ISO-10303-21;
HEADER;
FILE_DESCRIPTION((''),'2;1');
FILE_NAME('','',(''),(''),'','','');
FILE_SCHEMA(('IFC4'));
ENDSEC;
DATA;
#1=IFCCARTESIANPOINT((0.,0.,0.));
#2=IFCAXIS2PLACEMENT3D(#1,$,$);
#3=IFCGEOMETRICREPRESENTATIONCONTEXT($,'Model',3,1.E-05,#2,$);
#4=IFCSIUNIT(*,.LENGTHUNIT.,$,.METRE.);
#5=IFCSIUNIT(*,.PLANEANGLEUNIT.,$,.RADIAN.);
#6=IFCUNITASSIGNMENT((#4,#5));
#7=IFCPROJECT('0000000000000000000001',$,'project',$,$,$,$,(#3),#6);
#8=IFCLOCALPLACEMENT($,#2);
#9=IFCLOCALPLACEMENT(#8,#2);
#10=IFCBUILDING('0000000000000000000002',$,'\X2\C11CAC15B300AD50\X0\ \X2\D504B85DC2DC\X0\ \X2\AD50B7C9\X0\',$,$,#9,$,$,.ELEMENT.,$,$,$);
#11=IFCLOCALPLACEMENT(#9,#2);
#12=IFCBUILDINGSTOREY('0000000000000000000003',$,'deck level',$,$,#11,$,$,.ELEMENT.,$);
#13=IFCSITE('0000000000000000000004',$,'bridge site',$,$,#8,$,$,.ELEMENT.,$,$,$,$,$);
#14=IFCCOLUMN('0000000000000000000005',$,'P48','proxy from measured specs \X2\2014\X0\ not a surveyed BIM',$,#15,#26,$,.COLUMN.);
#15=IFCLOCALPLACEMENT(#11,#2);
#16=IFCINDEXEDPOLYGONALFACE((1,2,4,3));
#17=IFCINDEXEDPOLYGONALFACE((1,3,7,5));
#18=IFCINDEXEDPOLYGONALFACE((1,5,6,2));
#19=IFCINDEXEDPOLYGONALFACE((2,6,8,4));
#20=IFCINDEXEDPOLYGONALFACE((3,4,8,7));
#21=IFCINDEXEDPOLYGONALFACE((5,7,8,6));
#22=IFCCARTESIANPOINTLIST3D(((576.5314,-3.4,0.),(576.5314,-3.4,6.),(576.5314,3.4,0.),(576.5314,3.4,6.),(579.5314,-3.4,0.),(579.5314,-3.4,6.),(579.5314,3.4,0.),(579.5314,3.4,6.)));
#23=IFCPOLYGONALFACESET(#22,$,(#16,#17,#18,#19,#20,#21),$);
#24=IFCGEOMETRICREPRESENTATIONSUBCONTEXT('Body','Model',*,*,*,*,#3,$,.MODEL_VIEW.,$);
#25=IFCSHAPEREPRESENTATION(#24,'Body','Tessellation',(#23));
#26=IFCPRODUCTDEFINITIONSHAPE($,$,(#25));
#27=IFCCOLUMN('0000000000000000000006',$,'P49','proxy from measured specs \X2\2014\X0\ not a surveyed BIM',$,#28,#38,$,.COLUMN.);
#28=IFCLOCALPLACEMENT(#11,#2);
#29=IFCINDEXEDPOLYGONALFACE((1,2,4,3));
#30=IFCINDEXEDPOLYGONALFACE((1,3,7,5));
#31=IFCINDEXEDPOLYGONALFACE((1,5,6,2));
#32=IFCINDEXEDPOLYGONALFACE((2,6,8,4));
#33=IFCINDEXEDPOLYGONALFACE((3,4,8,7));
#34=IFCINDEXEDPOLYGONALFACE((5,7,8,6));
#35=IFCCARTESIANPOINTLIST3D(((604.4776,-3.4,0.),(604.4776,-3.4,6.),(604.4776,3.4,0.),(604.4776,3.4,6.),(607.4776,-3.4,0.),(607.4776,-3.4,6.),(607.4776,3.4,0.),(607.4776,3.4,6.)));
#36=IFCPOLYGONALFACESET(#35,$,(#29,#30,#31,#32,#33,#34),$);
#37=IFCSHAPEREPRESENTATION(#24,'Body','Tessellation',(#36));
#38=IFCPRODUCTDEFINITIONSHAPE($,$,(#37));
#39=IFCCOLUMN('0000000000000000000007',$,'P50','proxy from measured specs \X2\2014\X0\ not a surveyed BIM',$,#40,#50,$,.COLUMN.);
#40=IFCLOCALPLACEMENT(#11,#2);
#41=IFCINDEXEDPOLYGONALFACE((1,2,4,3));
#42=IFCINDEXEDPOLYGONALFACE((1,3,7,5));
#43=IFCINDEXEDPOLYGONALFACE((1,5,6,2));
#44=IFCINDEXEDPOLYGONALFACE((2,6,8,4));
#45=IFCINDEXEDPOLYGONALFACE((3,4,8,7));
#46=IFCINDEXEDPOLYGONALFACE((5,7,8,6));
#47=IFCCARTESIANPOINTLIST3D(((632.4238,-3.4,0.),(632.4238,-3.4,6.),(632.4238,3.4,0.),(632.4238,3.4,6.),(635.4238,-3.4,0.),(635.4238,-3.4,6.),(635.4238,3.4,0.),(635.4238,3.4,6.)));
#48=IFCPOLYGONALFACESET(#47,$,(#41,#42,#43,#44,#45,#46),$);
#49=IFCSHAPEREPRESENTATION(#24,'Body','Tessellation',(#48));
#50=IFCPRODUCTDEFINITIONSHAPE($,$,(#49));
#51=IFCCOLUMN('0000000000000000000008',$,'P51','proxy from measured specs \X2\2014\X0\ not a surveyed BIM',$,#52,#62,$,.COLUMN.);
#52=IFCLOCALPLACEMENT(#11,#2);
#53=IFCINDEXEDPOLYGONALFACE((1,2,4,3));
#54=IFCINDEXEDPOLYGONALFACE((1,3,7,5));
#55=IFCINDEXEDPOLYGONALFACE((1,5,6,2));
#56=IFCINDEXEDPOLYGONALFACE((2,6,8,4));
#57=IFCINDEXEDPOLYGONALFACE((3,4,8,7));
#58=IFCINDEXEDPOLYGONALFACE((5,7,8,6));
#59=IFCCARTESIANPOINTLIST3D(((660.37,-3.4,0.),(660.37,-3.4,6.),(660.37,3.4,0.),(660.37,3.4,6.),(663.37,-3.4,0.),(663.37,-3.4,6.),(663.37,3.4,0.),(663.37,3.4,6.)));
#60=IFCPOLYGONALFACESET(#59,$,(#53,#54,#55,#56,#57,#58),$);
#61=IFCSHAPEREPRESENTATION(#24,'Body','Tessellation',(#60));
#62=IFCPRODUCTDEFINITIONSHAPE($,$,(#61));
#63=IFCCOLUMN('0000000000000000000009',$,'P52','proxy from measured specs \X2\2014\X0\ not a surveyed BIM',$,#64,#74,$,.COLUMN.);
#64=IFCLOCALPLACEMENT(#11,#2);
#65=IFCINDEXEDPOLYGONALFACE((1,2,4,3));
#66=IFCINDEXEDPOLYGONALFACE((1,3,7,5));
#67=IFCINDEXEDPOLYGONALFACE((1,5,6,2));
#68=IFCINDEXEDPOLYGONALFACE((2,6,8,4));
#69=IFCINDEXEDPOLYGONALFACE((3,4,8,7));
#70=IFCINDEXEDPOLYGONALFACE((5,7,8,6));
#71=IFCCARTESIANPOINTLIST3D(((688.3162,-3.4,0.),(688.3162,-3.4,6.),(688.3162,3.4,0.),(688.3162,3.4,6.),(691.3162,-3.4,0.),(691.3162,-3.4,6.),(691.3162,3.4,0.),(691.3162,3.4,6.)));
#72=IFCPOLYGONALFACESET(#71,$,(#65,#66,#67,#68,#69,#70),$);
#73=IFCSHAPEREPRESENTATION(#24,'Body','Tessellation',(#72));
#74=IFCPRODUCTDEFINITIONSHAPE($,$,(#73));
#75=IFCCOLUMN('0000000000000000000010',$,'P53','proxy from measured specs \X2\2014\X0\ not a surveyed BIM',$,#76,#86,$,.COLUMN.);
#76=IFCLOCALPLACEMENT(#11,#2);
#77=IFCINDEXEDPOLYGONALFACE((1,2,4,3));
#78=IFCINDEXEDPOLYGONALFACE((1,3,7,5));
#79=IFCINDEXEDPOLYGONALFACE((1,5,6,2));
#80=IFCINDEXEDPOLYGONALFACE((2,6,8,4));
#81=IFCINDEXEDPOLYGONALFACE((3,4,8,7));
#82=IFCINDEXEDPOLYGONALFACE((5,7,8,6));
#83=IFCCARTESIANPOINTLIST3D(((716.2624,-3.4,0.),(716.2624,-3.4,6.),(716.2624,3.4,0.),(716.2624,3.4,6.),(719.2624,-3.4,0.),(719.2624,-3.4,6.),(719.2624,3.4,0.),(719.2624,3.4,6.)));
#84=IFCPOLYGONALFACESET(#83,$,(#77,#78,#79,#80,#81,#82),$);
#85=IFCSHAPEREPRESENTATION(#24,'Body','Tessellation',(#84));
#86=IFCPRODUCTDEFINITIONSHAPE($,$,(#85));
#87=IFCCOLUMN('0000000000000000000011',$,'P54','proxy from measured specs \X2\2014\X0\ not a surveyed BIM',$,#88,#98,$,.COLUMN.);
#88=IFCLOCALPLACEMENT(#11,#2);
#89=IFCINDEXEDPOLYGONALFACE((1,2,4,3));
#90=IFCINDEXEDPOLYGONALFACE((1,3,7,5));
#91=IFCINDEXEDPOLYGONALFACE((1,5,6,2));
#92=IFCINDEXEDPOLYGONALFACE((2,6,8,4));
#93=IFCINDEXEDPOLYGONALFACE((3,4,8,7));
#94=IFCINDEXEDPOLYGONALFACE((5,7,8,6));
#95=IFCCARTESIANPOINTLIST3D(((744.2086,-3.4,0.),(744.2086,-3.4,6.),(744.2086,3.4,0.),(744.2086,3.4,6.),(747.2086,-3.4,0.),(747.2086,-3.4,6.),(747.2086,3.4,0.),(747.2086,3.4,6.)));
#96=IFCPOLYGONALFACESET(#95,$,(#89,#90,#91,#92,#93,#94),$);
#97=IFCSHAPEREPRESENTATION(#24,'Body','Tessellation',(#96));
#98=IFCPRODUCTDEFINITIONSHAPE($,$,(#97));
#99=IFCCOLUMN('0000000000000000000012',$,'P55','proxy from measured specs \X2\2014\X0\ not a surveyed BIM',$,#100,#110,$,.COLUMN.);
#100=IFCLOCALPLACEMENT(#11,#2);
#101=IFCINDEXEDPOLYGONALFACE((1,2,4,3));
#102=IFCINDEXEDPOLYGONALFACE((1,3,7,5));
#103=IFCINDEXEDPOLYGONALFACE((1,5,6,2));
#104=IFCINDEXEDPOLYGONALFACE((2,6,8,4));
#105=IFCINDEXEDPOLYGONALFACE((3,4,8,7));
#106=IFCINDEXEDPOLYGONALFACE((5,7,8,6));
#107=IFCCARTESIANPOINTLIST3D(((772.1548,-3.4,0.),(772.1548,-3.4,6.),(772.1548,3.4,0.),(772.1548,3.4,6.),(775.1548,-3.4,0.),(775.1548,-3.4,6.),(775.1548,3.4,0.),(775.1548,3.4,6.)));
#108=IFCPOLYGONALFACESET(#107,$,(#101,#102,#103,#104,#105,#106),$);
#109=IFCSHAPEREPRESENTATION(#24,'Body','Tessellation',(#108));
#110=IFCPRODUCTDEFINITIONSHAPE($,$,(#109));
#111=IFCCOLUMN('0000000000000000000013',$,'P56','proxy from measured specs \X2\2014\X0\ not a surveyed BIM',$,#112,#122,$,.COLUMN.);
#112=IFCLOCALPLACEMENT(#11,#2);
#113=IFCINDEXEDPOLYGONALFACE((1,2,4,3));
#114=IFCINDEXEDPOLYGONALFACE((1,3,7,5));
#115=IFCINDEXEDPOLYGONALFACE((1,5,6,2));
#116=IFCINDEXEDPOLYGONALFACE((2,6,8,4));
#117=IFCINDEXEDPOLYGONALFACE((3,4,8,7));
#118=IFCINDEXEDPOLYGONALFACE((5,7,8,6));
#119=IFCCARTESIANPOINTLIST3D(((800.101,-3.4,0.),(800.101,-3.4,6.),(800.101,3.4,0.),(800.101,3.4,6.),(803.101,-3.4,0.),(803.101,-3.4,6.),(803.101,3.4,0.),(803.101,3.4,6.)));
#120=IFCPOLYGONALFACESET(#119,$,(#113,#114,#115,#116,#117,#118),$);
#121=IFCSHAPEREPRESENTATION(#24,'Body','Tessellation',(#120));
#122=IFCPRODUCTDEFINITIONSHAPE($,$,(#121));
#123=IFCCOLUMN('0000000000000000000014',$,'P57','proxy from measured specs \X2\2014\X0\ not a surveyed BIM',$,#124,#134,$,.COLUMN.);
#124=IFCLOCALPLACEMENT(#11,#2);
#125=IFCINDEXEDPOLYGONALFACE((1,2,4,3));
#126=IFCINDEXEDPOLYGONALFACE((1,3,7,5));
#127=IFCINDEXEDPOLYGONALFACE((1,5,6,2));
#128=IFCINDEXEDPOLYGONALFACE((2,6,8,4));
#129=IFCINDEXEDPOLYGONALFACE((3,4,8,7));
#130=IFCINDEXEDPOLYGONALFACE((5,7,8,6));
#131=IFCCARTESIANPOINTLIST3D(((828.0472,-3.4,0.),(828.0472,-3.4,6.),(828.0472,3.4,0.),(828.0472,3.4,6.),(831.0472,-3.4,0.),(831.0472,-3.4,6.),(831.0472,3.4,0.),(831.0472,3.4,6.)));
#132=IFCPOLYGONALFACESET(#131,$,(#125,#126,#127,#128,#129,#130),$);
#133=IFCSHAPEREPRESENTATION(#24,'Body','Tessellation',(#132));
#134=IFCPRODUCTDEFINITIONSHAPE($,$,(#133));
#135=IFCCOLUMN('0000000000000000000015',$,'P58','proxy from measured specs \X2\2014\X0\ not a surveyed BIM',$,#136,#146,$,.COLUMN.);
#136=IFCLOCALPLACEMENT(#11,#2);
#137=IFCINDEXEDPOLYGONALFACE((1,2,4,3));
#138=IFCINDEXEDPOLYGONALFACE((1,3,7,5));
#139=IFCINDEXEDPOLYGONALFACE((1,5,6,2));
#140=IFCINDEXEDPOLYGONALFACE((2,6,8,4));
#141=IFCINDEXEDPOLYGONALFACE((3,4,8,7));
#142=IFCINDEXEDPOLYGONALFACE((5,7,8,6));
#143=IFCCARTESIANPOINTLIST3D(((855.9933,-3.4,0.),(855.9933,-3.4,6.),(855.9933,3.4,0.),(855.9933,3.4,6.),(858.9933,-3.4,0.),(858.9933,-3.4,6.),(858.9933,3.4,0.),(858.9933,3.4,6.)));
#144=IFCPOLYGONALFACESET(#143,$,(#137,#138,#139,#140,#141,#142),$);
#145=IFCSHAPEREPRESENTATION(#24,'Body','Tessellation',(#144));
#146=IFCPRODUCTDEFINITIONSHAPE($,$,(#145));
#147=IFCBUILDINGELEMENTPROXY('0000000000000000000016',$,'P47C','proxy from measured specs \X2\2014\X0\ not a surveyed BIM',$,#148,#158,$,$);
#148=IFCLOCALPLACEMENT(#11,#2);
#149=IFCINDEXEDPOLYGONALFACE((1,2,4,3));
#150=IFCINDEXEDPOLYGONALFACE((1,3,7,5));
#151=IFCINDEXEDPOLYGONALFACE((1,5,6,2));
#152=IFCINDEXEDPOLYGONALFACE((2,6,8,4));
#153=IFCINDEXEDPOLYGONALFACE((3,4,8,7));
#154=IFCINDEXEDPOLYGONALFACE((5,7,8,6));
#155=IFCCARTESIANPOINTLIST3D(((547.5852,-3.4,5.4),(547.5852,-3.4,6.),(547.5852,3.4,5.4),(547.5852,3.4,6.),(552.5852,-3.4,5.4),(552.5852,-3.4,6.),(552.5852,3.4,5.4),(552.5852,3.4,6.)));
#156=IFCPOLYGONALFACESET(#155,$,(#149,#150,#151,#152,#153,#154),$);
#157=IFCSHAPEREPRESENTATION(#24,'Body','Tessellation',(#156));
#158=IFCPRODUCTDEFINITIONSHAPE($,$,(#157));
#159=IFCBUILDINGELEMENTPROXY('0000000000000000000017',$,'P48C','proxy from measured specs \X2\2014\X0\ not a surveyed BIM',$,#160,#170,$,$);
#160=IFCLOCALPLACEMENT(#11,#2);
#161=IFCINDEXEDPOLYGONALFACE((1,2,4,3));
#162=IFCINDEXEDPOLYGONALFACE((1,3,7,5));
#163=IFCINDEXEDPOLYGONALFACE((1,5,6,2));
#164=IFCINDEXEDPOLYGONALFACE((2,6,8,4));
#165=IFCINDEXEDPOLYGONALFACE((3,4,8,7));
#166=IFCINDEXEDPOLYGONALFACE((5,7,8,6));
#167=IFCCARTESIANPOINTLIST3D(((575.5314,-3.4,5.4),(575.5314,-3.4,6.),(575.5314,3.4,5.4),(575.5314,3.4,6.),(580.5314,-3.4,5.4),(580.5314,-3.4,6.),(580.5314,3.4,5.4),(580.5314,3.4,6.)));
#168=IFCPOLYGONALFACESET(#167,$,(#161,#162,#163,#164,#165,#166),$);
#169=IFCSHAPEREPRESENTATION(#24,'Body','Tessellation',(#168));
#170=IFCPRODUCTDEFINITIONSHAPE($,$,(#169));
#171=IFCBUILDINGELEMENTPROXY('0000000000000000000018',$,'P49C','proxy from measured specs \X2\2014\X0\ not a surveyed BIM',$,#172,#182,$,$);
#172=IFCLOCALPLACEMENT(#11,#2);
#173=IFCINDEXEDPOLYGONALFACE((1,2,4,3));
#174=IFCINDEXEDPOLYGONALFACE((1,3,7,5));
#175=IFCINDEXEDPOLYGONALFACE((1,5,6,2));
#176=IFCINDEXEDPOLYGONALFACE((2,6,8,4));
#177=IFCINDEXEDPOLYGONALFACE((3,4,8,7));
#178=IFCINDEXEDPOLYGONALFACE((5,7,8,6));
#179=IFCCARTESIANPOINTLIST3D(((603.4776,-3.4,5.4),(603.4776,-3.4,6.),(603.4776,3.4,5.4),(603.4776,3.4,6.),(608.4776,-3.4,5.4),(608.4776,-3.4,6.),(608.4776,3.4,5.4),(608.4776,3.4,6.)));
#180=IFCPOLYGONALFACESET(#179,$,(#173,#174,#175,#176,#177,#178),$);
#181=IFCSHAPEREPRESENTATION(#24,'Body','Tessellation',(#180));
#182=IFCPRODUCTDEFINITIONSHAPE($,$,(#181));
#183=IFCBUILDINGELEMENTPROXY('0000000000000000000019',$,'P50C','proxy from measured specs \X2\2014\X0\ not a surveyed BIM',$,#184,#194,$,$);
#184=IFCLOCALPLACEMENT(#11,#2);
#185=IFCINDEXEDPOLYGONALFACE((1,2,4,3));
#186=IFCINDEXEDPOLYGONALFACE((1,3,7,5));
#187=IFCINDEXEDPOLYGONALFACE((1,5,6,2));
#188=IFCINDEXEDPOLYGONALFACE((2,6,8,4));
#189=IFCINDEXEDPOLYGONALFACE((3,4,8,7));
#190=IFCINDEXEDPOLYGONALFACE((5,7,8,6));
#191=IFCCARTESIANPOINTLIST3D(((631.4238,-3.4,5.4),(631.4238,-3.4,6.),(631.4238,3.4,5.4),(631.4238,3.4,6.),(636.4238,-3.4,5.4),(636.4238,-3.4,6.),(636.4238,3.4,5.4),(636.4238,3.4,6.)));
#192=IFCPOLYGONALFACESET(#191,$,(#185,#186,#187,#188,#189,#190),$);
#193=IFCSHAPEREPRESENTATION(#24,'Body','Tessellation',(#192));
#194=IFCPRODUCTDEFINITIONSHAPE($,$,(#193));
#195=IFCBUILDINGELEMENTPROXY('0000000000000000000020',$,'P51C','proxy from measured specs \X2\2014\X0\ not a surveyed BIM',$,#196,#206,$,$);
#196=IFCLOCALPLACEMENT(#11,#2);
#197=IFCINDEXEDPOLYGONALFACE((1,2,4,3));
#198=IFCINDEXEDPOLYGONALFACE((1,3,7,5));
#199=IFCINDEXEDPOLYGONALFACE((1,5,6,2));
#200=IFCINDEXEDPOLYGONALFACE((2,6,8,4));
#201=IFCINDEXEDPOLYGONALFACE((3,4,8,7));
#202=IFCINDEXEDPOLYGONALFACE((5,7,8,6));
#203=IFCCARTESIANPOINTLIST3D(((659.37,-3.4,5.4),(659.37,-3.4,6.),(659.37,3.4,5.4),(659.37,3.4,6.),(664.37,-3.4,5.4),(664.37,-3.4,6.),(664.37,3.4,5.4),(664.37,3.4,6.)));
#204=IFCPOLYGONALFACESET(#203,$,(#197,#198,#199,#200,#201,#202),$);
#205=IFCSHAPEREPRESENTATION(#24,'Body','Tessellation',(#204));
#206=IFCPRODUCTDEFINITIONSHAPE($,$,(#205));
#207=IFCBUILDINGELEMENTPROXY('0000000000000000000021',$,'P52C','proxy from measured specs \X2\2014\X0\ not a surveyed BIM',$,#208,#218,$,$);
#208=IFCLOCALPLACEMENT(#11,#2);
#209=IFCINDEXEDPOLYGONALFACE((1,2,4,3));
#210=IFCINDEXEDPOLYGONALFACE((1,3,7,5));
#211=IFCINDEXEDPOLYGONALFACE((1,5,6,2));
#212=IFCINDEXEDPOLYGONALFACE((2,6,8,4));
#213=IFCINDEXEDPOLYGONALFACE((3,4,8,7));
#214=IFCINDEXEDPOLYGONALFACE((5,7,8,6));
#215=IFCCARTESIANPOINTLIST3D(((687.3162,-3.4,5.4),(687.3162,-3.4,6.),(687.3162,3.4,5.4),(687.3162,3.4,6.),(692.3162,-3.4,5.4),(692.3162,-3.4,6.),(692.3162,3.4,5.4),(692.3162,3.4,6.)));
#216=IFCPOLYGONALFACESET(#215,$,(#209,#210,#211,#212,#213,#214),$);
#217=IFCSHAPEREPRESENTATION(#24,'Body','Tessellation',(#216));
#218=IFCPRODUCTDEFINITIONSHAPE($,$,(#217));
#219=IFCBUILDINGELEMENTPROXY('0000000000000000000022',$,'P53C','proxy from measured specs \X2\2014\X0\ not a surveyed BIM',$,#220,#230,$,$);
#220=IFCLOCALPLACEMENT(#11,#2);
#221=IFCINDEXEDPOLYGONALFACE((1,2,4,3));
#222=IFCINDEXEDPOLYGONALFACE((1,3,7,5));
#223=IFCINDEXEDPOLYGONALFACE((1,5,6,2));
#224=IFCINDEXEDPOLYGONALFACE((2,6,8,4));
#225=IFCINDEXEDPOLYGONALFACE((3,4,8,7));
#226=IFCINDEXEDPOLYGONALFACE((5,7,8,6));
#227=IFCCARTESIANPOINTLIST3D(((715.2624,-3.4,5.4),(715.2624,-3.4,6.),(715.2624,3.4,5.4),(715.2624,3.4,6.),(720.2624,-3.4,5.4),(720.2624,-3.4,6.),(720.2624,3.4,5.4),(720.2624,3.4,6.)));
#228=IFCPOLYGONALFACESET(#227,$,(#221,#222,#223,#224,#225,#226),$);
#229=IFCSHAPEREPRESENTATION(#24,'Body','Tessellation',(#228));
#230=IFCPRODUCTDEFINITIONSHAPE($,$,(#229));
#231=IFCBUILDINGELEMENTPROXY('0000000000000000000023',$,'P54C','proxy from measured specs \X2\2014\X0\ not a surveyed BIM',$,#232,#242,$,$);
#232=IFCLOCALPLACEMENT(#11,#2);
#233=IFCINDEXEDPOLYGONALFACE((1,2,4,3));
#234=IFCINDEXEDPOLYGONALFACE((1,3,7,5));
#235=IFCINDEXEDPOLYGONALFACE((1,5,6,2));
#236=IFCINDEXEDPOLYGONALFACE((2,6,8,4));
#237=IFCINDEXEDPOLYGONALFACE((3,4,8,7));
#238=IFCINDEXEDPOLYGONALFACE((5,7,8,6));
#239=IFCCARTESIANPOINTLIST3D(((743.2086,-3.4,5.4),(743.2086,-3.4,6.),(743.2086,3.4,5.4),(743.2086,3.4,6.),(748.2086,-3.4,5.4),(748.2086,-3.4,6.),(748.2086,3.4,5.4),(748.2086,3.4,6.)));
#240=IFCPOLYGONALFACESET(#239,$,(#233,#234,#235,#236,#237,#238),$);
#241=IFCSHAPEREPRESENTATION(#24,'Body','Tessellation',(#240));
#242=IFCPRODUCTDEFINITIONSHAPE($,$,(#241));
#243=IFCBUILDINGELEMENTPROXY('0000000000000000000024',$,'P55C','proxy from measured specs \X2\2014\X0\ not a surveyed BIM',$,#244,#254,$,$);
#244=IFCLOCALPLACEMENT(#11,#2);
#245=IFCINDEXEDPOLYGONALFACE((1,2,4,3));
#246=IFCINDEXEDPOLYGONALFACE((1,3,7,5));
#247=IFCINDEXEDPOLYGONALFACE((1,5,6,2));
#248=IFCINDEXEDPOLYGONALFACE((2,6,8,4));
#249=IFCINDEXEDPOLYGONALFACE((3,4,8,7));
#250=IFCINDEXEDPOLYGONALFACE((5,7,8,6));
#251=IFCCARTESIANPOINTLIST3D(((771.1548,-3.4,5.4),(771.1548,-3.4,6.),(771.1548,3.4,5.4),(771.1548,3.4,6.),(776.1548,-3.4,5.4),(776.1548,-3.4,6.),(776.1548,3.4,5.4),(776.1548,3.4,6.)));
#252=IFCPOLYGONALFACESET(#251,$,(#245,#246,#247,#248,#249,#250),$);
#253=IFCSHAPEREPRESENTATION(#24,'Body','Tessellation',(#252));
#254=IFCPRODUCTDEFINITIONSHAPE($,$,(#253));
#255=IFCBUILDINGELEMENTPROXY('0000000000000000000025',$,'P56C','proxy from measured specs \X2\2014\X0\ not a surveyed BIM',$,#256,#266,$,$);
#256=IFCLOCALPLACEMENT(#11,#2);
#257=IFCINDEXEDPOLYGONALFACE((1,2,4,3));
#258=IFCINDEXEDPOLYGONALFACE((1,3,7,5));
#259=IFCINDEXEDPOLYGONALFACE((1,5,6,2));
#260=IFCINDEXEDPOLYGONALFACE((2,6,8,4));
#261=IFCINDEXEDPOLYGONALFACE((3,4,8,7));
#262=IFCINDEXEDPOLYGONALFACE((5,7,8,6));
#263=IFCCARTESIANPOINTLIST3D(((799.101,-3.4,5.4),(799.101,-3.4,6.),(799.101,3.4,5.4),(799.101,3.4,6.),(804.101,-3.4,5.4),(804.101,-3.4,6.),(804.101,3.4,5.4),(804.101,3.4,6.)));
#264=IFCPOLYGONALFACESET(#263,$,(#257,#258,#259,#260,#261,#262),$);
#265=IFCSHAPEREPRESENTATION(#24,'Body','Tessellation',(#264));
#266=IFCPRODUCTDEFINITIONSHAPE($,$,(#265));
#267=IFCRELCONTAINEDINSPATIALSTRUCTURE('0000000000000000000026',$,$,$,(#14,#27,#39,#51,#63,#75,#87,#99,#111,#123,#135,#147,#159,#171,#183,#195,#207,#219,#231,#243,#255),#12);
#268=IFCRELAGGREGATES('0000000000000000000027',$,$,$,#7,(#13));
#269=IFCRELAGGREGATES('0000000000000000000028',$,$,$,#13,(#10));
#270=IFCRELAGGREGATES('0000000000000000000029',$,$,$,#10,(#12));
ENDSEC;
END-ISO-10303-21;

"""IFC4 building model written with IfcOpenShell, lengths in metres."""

from ifc_helpers import new_model, si_unit, frame, origin, origin_2d, place, context, subcontext, project, spatial, rectangle, extrude, element, save


model = new_model("IFC4")

# Units and contexts
model_context = context("Model", 3, precision=1e-05, world=origin())
body_context = subcontext(model_context, "Body", "Model", "MODEL_VIEW")
ifc_project = project(units=[si_unit("LENGTHUNIT", "METRE"), si_unit("PLANEANGLEUNIT", "RADIAN")], contexts=[model_context])

# Site, building, storey
site_placement = place(None, origin())
site = spatial("IfcSite", under=ifc_project, at=site_placement, Name="bridge site", CompositionType="ELEMENT")
building_placement = place(site_placement, origin())
building = spatial("IfcBuilding", under=site, at=building_placement, Name="서강대교 프록시 교량", CompositionType="ELEMENT")
storey_placement = place(building_placement, origin())
storey = spatial("IfcBuildingStorey", under=building, at=storey_placement, Name="deck level", CompositionType="ELEMENT")

# Columns
for number, where, name in (
    (1, (578.0314, 0.0, 0.0), "P48"),
    (2, (605.9776, 0.0, 0.0), "P49"),
    (3, (633.9238, 0.0, 0.0), "P50"),
    (4, (661.87, 0.0, 0.0), "P51"),
    (5, (689.8162, 0.0, 0.0), "P52"),
    (6, (717.7624, 0.0, 0.0), "P53"),
    (7, (745.7086, 0.0, 0.0), "P54"),
    (8, (773.6548, 0.0, 0.0), "P55"),
    (9, (801.601, 0.0, 0.0), "P56"),
    (10, (829.5472, 0.0, 0.0), "P57"),
    (11, (857.4933, 0.0, 0.0), "P58"),
):
    element("IfcColumn", number, at=place(storey_placement, frame(where)), inside=storey, Name=name, Description="proxy from measured specs — not a surveyed BIM", PredefinedType="COLUMN", context=body_context, shape_type="SweptSolid", body=[
        extrude(rectangle(XDim=3.0, YDim=6.8, at=origin_2d()), origin(), (0.0, 0.0, 1.0), 6.0),
    ])

# Building element proxies
for number, where, name in (
    (12, (550.0852, 0.0, 5.4), "P47C"),
    (13, (578.0314, 0.0, 5.4), "P48C"),
    (14, (605.9776, 0.0, 5.4), "P49C"),
    (15, (633.9238, 0.0, 5.4), "P50C"),
    (16, (661.87, 0.0, 5.4), "P51C"),
    (17, (689.8162, 0.0, 5.4), "P52C"),
    (18, (717.7624, 0.0, 5.4), "P53C"),
    (19, (745.7086, 0.0, 5.4), "P54C"),
    (20, (773.6548, 0.0, 5.4), "P55C"),
    (21, (801.601, 0.0, 5.4), "P56C"),
):
    element("IfcBuildingElementProxy", number, at=place(storey_placement, frame(where)), inside=storey, Name=name, Description="proxy from measured specs — not a surveyed BIM", context=body_context, shape_type="SweptSolid", body=[
        extrude(rectangle(XDim=5.0, YDim=6.8, at=origin_2d()), origin(), (0.0, 0.0, 1.0), 0.6),
    ])

save(model, "model.ifc")
